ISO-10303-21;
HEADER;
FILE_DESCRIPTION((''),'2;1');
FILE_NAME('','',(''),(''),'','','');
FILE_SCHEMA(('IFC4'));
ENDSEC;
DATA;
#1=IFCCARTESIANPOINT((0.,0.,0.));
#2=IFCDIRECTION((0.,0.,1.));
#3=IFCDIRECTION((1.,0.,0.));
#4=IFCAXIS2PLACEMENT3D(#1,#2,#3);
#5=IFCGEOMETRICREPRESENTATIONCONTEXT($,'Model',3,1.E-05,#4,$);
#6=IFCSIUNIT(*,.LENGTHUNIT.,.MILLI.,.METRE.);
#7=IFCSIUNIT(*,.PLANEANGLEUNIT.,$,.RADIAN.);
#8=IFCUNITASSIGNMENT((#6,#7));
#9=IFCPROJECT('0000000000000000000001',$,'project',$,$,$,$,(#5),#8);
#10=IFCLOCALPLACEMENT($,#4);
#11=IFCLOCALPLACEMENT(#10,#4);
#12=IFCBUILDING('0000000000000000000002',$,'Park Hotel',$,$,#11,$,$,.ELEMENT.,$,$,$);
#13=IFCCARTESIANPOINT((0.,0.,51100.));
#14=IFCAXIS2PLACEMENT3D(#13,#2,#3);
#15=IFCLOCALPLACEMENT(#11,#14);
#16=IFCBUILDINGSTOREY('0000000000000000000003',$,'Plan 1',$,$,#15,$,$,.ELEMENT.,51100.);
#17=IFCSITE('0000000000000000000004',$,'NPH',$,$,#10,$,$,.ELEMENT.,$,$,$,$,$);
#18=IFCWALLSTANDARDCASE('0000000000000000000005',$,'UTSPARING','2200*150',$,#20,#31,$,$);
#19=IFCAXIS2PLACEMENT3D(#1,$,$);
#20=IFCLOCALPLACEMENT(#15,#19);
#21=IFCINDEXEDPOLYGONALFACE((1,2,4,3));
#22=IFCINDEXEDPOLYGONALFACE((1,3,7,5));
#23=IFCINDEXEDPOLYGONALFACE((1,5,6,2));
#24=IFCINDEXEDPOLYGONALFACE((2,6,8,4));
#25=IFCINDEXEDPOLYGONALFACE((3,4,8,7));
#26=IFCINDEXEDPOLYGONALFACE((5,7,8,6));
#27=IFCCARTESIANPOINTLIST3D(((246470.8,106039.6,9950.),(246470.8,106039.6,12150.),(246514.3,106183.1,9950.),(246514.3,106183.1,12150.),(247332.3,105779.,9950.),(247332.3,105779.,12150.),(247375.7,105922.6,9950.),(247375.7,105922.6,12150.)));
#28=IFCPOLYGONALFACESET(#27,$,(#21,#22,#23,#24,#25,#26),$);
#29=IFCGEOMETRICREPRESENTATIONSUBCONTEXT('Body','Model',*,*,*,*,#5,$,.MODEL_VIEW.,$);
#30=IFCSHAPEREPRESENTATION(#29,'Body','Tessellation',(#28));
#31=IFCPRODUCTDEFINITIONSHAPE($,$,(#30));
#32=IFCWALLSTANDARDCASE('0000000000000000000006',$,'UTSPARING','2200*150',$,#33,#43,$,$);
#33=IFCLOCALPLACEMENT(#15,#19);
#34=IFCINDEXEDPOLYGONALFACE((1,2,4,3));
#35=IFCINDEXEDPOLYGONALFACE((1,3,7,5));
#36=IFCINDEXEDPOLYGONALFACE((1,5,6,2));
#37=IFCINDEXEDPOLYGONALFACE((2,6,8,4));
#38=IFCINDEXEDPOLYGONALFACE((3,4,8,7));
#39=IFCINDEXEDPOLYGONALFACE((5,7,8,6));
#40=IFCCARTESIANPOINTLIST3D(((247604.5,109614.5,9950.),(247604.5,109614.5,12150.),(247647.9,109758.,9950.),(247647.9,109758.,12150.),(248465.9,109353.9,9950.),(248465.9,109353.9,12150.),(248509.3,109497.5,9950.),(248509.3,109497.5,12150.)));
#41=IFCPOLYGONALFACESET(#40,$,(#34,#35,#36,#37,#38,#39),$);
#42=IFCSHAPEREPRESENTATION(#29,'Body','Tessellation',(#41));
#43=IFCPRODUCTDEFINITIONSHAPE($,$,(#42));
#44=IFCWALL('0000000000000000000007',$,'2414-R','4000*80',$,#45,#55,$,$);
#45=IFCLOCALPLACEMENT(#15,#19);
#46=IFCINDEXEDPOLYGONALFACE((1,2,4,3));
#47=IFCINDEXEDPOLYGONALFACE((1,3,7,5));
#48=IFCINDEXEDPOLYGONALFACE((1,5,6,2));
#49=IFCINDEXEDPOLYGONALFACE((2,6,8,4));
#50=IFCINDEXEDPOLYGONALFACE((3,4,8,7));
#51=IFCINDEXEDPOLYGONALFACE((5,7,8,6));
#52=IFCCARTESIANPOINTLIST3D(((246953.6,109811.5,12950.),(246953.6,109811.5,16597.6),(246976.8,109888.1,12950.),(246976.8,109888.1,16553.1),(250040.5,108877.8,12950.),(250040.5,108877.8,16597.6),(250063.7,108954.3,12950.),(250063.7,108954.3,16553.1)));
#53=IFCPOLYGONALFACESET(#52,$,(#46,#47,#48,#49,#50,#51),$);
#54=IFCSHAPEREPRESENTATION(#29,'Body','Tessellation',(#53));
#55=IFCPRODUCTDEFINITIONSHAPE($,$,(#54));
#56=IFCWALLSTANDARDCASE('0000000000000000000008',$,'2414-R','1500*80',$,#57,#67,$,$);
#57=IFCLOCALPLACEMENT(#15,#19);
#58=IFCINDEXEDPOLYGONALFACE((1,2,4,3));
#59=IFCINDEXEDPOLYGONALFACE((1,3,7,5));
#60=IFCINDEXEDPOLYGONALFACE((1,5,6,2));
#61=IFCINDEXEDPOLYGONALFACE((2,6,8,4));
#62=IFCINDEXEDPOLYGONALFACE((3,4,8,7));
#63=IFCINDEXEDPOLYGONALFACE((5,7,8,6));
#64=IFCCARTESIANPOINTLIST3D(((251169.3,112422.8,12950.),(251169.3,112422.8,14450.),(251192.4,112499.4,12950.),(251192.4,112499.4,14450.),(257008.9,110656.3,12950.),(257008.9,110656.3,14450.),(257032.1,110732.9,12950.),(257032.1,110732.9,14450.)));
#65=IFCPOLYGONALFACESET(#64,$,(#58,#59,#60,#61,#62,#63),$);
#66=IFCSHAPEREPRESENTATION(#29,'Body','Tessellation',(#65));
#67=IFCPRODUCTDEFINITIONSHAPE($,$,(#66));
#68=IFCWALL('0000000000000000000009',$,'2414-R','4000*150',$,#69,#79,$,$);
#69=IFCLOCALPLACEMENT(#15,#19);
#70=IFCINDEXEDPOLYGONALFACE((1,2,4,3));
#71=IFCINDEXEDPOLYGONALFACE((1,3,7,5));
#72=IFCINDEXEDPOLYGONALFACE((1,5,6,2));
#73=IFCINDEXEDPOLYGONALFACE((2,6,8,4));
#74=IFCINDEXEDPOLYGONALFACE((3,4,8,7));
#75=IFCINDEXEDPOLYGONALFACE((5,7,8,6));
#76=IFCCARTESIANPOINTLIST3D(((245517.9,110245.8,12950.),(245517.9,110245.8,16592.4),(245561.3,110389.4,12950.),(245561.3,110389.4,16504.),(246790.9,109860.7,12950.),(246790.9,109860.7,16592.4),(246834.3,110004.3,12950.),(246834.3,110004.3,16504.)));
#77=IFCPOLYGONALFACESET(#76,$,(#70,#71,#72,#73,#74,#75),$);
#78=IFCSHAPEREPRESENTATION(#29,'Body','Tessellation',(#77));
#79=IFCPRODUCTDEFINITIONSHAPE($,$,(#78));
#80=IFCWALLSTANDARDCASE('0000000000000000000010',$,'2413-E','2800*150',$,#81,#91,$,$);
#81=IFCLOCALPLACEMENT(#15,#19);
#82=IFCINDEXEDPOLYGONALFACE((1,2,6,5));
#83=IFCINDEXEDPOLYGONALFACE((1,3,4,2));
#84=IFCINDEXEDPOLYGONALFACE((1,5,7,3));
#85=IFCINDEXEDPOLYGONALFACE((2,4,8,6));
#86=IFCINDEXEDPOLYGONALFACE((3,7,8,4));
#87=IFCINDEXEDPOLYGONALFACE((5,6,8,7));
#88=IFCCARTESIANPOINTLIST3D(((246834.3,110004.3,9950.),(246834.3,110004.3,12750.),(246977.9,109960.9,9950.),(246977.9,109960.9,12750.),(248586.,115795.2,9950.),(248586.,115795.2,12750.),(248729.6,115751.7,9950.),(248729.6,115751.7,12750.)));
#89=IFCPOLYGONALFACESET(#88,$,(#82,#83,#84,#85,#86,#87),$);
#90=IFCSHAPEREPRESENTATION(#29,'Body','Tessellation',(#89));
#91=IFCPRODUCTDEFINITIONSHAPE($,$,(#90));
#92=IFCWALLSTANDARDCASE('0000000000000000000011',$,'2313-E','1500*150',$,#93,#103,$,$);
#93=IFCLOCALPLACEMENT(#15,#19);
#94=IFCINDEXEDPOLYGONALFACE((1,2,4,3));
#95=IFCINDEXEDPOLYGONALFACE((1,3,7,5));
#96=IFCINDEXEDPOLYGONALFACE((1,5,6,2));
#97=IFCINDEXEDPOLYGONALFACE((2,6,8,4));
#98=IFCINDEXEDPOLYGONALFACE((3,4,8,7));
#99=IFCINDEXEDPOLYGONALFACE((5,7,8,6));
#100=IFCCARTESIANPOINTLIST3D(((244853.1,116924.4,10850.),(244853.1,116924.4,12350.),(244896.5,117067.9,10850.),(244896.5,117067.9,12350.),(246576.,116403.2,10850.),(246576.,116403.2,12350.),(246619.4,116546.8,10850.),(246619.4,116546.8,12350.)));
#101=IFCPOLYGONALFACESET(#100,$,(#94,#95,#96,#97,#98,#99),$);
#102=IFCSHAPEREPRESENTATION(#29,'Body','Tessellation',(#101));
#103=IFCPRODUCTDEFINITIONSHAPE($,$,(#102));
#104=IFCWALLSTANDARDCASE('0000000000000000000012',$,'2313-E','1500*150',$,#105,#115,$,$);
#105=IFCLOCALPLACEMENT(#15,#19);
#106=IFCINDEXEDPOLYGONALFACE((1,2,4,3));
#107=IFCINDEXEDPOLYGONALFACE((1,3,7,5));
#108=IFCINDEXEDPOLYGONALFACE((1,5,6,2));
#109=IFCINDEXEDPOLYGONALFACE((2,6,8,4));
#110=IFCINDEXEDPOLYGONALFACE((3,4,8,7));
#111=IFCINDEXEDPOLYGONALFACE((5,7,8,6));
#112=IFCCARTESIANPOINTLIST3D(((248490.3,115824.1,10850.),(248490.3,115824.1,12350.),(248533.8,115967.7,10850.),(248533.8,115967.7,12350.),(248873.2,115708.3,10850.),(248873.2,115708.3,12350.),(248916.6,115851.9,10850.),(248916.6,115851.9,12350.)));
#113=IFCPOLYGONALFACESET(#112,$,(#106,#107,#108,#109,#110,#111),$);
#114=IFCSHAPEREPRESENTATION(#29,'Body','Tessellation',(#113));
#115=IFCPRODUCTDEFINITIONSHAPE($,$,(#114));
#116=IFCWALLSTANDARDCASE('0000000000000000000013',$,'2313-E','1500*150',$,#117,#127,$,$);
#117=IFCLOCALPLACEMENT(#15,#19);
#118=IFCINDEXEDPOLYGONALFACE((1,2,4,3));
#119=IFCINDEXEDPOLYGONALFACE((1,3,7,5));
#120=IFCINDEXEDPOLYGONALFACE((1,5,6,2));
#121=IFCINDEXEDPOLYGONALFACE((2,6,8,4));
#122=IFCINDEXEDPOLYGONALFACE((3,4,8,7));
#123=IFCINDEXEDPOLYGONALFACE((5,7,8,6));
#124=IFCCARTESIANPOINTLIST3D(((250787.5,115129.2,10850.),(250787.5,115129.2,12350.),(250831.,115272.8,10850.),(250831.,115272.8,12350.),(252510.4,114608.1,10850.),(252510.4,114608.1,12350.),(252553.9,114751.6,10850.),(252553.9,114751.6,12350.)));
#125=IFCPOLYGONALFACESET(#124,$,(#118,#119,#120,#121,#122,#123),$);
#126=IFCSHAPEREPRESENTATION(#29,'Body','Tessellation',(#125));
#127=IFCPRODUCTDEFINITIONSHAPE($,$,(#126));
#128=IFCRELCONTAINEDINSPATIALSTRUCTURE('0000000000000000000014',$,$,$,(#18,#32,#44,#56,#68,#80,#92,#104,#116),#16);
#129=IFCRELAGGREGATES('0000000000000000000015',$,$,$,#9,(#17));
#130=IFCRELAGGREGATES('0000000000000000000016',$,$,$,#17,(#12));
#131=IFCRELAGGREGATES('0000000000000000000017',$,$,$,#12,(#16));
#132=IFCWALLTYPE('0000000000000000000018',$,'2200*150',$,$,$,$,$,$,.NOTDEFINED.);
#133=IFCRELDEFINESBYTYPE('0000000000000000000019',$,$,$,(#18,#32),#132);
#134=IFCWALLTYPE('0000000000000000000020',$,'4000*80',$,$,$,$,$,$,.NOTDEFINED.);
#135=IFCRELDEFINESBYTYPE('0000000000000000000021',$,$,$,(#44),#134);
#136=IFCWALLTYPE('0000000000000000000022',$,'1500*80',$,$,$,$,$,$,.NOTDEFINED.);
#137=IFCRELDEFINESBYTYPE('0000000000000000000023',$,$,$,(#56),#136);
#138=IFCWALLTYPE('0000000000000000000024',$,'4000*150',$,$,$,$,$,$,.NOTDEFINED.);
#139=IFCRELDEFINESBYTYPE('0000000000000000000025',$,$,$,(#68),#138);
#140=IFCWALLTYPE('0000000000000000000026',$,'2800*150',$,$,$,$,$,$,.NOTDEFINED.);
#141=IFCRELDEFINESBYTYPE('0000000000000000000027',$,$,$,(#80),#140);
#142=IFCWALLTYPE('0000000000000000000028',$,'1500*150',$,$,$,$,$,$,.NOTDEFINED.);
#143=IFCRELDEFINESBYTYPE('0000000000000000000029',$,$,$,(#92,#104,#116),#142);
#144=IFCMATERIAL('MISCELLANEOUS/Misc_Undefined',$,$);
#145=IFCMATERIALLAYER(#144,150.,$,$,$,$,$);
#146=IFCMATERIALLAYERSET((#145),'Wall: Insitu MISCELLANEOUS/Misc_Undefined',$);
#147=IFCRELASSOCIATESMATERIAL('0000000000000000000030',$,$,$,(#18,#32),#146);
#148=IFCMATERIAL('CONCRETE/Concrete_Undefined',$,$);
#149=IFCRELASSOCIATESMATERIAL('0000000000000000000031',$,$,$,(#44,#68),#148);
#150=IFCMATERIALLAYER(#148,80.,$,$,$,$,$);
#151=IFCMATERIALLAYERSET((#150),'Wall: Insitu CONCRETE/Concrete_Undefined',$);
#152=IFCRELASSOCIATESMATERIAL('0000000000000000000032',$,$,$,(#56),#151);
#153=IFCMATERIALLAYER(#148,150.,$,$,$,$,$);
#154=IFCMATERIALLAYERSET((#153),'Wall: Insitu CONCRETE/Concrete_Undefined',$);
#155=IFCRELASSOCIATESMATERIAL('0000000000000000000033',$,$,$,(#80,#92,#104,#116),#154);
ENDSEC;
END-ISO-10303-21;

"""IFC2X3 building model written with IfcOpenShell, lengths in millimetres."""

from ifc_helpers import new_model, si_unit, frame, frame_2d, origin_with_axes, place, context, subcontext, project, spatial, rectangle, extrude, clip, halfspace, material, layer, layer_set, layer_usage, type_object, element, save


model = new_model("IFC2X3")

# Units and contexts
model_context = context("Model", 3, precision=1e-05, world=origin_with_axes())
body_context = subcontext(model_context, "Body", "Model", "MODEL_VIEW")
ifc_project = project(units=[si_unit("LENGTHUNIT", "METRE", prefix="MILLI"), si_unit("PLANEANGLEUNIT", "RADIAN")], contexts=[model_context])

# Site, building, storey
site_placement = place(None, origin_with_axes())
site = spatial("IfcSite", under=ifc_project, at=site_placement, Name="NPH", CompositionType="ELEMENT")
building_placement = place(site_placement, origin_with_axes())
building = spatial("IfcBuilding", under=site, at=building_placement, Name="Park Hotel", CompositionType="ELEMENT")
storey_placement = place(building_placement, frame((0.0, 0.0, 51100.0), z_axis=(0.0, 0.0, 1.0), x_axis=(1.0, 0.0, 0.0)))
storey = spatial("IfcBuildingStorey", under=building, at=storey_placement, Name="Plan 1", CompositionType="ELEMENT", Elevation=51100.0)

# Walls
ifc_material_1 = material(Name="CONCRETE/Concrete_Undefined")
ifc_material_2 = material(Name="MISCELLANEOUS/Misc_Undefined")
ifc_layer_1 = layer(ifc_material_2, 150.0)
ifc_layer_set_1 = layer_set([ifc_layer_1], Name="Wall: Insitu MISCELLANEOUS/Misc_Undefined")
wall_type_1 = type_object("IfcWallType", Name="2200*150", PredefinedType="NOTDEFINED")
ifc_layer_usage_1 = layer_usage(ifc_layer_set_1, "AXIS2", "POSITIVE", -75.0)
wall_1_placement = place(storey_placement, frame((246492.6, 106111.4, 9950.0), z_axis=(0.0, 0.0, 1.0), x_axis=(0.957166, -0.289541, 0.0)))
element("IfcWallStandardCase", 1, at=wall_1_placement, inside=storey, type_object=wall_type_1, material=ifc_layer_usage_1, Name="UTSPARING", Description="2200*150", context=body_context, shape_type="SweptSolid", body=[
    extrude(rectangle(XDim=900.0, YDim=150.0, at=frame_2d((0.0, 450.0), x_axis=(0.0, -1.0))), frame((0.0, 0.0, 0.0), z_axis=(0.0, 0.0, 1.0), x_axis=(0.0, -1.0, 0.0)), (0.0, 0.0, 1.0), 2200.0),
])
ifc_layer_usage_2 = layer_usage(ifc_layer_set_1, "AXIS2", "POSITIVE", -75.0)
wall_2_placement = place(storey_placement, frame((247626.2, 109686.3, 9950.0), z_axis=(0.0, 0.0, 1.0), x_axis=(0.957166, -0.289541, 0.0)))
element("IfcWallStandardCase", 2, at=wall_2_placement, inside=storey, type_object=wall_type_1, material=ifc_layer_usage_2, Name="UTSPARING", Description="2200*150", context=body_context, shape_type="SweptSolid", body=[
    extrude(rectangle(XDim=900.0, YDim=150.0, at=frame_2d((0.0, 450.0), x_axis=(0.0, -1.0))), frame((0.0, 0.0, 0.0), z_axis=(0.0, 0.0, 1.0), x_axis=(0.0, -1.0, 0.0)), (0.0, 0.0, 1.0), 2200.0),
])
wall_type_2 = type_object("IfcWallType", Name="4000*80", PredefinedType="NOTDEFINED")
wall_3_placement = place(storey_placement, frame((246965.2, 109849.8, 13126.2), z_axis=(0.0, 0.0, 1.0), x_axis=(0.957167, -0.289536, 0.0)))
element("IfcWall", 3, at=wall_3_placement, inside=storey, type_object=wall_type_2, material=ifc_material_1, Name="2414-R", Description="4000*80", context=body_context, shape_type="Clipping", body=[
    clip(extrude(rectangle(XDim=3225.0, YDim=80.0, at=frame_2d((0.0, 1612.5), x_axis=(0.0, -1.0))), frame((0.0, 0.0, -176.2), z_axis=(0.0, 0.0, 1.0), x_axis=(0.0, -1.0, 0.0)), (0.0, 0.0, 1.0), 4000.0), halfspace(frame((3225.0, 40.0, 3426.9), z_axis=(0.000001, 0.486531, 0.873663), x_axis=(0.0, -0.873663, 0.486531)), False)),
])
ifc_layer_2 = layer(ifc_material_1, 80.0)
ifc_layer_set_2 = layer_set([ifc_layer_2], Name="Wall: Insitu CONCRETE/Concrete_Undefined")
ifc_layer_usage_3 = layer_usage(ifc_layer_set_2, "AXIS2", "POSITIVE", -40.0)
wall_type_3 = type_object("IfcWallType", Name="1500*80", PredefinedType="NOTDEFINED")
wall_4_placement = place(storey_placement, frame((251180.8, 112461.1, 12950.0), z_axis=(0.0, 0.0, 1.0), x_axis=(0.957167, -0.289537, 0.0)))
element("IfcWallStandardCase", 4, at=wall_4_placement, inside=storey, type_object=wall_type_3, material=ifc_layer_usage_3, Name="2414-R", Description="1500*80", context=body_context, shape_type="SweptSolid", body=[
    extrude(rectangle(XDim=6101.0, YDim=80.0, at=frame_2d((0.0, 3050.5), x_axis=(0.0, -1.0))), frame((0.0, 0.0, 0.0), z_axis=(0.0, 0.0, 1.0), x_axis=(0.0, -1.0, 0.0)), (0.0, 0.0, 1.0), 1500.0),
])
wall_type_4 = type_object("IfcWallType", Name="4000*150", PredefinedType="NOTDEFINED")
wall_5_placement = place(storey_placement, frame((245539.6, 110317.6, 13128.8), z_axis=(0.0, 0.0, 1.0), x_axis=(0.957166, -0.289541, 0.0)))
element("IfcWall", 5, at=wall_5_placement, inside=storey, type_object=wall_type_4, material=ifc_material_1, Name="2414-R", Description="4000*150", context=body_context, shape_type="Clipping", body=[
    clip(extrude(rectangle(XDim=1330.0, YDim=150.0, at=frame_2d((0.0, 665.0), x_axis=(0.0, -1.0))), frame((0.0, 0.0, -178.8), z_axis=(0.0, 0.0, 1.0), x_axis=(0.0, -1.0, 0.0)), (0.0, 0.0, 1.0), 4000.0), halfspace(frame((1330.0, 75.0, 3375.2), z_axis=(0.0, 0.508027, 0.861341), x_axis=(0.0, -0.861341, 0.508027)), False)),
])
ifc_layer_3 = layer(ifc_material_1, 150.0)
ifc_layer_set_3 = layer_set([ifc_layer_3], Name="Wall: Insitu CONCRETE/Concrete_Undefined")
ifc_layer_usage_4 = layer_usage(ifc_layer_set_3, "AXIS2", "POSITIVE", -75.0)
wall_type_5 = type_object("IfcWallType", Name="2800*150", PredefinedType="NOTDEFINED")
wall_6_placement = place(storey_placement, frame((246906.1, 109982.6, 9950.0), z_axis=(0.0, 0.0, 1.0), x_axis=(0.289537, 0.957167, 0.0)))
element("IfcWallStandardCase", 6, at=wall_6_placement, inside=storey, type_object=wall_type_5, material=ifc_layer_usage_4, Name="2413-E", Description="2800*150", context=body_context, shape_type="SweptSolid", body=[
    extrude(rectangle(XDim=6050.0, YDim=150.0, at=frame_2d((0.0, 3025.0), x_axis=(0.0, -1.0))), frame((0.0, 0.0, 0.0), z_axis=(0.0, 0.0, 1.0), x_axis=(0.0, -1.0, 0.0)), (0.0, 0.0, 1.0), 2800.0),
])
ifc_layer_usage_5 = layer_usage(ifc_layer_set_3, "AXIS2", "POSITIVE", -75.0)
wall_type_6 = type_object("IfcWallType", Name="1500*150", PredefinedType="NOTDEFINED")
wall_7_placement = place(storey_placement, frame((244874.8, 116996.2, 10850.0), z_axis=(0.0, 0.0, 1.0), x_axis=(0.957166, -0.289541, 0.0)))
element("IfcWallStandardCase", 7, at=wall_7_placement, inside=storey, type_object=wall_type_6, material=ifc_layer_usage_5, Name="2313-E", Description="1500*150", context=body_context, shape_type="SweptSolid", body=[
    extrude(rectangle(XDim=1800.0, YDim=150.0, at=frame_2d((0.0, 900.0), x_axis=(0.0, -1.0))), frame((0.0, 0.0, 0.0), z_axis=(0.0, 0.0, 1.0), x_axis=(0.0, -1.0, 0.0)), (0.0, 0.0, 1.0), 1500.0),
])
ifc_layer_usage_6 = layer_usage(ifc_layer_set_3, "AXIS2", "POSITIVE", -75.0)
wall_8_placement = place(storey_placement, frame((248512.1, 115895.9, 10850.0), z_axis=(0.0, 0.0, 1.0), x_axis=(0.957161, -0.289556, 0.0)))
element("IfcWallStandardCase", 8, at=wall_8_placement, inside=storey, type_object=wall_type_6, material=ifc_layer_usage_6, Name="2313-E", Description="1500*150", context=body_context, shape_type="SweptSolid", body=[
    extrude(rectangle(XDim=400.0, YDim=150.0, at=frame_2d((0.0, 200.0), x_axis=(0.0, -1.0))), frame((0.0, 0.0, 0.0), z_axis=(0.0, 0.0, 1.0), x_axis=(0.0, -1.0, 0.0)), (0.0, 0.0, 1.0), 1500.0),
])
ifc_layer_usage_7 = layer_usage(ifc_layer_set_3, "AXIS2", "POSITIVE", -75.0)
wall_9_placement = place(storey_placement, frame((250809.3, 115201.0, 10850.0), z_axis=(0.0, 0.0, 1.0), x_axis=(0.957166, -0.289541, 0.0)))
element("IfcWallStandardCase", 9, at=wall_9_placement, inside=storey, type_object=wall_type_6, material=ifc_layer_usage_7, Name="2313-E", Description="1500*150", context=body_context, shape_type="SweptSolid", body=[
    extrude(rectangle(XDim=1800.0, YDim=150.0, at=frame_2d((0.0, 900.0), x_axis=(0.0, -1.0))), frame((0.0, 0.0, 0.0), z_axis=(0.0, 0.0, 1.0), x_axis=(0.0, -1.0, 0.0)), (0.0, 0.0, 1.0), 1500.0),
])

save(model, "model.ifc")
